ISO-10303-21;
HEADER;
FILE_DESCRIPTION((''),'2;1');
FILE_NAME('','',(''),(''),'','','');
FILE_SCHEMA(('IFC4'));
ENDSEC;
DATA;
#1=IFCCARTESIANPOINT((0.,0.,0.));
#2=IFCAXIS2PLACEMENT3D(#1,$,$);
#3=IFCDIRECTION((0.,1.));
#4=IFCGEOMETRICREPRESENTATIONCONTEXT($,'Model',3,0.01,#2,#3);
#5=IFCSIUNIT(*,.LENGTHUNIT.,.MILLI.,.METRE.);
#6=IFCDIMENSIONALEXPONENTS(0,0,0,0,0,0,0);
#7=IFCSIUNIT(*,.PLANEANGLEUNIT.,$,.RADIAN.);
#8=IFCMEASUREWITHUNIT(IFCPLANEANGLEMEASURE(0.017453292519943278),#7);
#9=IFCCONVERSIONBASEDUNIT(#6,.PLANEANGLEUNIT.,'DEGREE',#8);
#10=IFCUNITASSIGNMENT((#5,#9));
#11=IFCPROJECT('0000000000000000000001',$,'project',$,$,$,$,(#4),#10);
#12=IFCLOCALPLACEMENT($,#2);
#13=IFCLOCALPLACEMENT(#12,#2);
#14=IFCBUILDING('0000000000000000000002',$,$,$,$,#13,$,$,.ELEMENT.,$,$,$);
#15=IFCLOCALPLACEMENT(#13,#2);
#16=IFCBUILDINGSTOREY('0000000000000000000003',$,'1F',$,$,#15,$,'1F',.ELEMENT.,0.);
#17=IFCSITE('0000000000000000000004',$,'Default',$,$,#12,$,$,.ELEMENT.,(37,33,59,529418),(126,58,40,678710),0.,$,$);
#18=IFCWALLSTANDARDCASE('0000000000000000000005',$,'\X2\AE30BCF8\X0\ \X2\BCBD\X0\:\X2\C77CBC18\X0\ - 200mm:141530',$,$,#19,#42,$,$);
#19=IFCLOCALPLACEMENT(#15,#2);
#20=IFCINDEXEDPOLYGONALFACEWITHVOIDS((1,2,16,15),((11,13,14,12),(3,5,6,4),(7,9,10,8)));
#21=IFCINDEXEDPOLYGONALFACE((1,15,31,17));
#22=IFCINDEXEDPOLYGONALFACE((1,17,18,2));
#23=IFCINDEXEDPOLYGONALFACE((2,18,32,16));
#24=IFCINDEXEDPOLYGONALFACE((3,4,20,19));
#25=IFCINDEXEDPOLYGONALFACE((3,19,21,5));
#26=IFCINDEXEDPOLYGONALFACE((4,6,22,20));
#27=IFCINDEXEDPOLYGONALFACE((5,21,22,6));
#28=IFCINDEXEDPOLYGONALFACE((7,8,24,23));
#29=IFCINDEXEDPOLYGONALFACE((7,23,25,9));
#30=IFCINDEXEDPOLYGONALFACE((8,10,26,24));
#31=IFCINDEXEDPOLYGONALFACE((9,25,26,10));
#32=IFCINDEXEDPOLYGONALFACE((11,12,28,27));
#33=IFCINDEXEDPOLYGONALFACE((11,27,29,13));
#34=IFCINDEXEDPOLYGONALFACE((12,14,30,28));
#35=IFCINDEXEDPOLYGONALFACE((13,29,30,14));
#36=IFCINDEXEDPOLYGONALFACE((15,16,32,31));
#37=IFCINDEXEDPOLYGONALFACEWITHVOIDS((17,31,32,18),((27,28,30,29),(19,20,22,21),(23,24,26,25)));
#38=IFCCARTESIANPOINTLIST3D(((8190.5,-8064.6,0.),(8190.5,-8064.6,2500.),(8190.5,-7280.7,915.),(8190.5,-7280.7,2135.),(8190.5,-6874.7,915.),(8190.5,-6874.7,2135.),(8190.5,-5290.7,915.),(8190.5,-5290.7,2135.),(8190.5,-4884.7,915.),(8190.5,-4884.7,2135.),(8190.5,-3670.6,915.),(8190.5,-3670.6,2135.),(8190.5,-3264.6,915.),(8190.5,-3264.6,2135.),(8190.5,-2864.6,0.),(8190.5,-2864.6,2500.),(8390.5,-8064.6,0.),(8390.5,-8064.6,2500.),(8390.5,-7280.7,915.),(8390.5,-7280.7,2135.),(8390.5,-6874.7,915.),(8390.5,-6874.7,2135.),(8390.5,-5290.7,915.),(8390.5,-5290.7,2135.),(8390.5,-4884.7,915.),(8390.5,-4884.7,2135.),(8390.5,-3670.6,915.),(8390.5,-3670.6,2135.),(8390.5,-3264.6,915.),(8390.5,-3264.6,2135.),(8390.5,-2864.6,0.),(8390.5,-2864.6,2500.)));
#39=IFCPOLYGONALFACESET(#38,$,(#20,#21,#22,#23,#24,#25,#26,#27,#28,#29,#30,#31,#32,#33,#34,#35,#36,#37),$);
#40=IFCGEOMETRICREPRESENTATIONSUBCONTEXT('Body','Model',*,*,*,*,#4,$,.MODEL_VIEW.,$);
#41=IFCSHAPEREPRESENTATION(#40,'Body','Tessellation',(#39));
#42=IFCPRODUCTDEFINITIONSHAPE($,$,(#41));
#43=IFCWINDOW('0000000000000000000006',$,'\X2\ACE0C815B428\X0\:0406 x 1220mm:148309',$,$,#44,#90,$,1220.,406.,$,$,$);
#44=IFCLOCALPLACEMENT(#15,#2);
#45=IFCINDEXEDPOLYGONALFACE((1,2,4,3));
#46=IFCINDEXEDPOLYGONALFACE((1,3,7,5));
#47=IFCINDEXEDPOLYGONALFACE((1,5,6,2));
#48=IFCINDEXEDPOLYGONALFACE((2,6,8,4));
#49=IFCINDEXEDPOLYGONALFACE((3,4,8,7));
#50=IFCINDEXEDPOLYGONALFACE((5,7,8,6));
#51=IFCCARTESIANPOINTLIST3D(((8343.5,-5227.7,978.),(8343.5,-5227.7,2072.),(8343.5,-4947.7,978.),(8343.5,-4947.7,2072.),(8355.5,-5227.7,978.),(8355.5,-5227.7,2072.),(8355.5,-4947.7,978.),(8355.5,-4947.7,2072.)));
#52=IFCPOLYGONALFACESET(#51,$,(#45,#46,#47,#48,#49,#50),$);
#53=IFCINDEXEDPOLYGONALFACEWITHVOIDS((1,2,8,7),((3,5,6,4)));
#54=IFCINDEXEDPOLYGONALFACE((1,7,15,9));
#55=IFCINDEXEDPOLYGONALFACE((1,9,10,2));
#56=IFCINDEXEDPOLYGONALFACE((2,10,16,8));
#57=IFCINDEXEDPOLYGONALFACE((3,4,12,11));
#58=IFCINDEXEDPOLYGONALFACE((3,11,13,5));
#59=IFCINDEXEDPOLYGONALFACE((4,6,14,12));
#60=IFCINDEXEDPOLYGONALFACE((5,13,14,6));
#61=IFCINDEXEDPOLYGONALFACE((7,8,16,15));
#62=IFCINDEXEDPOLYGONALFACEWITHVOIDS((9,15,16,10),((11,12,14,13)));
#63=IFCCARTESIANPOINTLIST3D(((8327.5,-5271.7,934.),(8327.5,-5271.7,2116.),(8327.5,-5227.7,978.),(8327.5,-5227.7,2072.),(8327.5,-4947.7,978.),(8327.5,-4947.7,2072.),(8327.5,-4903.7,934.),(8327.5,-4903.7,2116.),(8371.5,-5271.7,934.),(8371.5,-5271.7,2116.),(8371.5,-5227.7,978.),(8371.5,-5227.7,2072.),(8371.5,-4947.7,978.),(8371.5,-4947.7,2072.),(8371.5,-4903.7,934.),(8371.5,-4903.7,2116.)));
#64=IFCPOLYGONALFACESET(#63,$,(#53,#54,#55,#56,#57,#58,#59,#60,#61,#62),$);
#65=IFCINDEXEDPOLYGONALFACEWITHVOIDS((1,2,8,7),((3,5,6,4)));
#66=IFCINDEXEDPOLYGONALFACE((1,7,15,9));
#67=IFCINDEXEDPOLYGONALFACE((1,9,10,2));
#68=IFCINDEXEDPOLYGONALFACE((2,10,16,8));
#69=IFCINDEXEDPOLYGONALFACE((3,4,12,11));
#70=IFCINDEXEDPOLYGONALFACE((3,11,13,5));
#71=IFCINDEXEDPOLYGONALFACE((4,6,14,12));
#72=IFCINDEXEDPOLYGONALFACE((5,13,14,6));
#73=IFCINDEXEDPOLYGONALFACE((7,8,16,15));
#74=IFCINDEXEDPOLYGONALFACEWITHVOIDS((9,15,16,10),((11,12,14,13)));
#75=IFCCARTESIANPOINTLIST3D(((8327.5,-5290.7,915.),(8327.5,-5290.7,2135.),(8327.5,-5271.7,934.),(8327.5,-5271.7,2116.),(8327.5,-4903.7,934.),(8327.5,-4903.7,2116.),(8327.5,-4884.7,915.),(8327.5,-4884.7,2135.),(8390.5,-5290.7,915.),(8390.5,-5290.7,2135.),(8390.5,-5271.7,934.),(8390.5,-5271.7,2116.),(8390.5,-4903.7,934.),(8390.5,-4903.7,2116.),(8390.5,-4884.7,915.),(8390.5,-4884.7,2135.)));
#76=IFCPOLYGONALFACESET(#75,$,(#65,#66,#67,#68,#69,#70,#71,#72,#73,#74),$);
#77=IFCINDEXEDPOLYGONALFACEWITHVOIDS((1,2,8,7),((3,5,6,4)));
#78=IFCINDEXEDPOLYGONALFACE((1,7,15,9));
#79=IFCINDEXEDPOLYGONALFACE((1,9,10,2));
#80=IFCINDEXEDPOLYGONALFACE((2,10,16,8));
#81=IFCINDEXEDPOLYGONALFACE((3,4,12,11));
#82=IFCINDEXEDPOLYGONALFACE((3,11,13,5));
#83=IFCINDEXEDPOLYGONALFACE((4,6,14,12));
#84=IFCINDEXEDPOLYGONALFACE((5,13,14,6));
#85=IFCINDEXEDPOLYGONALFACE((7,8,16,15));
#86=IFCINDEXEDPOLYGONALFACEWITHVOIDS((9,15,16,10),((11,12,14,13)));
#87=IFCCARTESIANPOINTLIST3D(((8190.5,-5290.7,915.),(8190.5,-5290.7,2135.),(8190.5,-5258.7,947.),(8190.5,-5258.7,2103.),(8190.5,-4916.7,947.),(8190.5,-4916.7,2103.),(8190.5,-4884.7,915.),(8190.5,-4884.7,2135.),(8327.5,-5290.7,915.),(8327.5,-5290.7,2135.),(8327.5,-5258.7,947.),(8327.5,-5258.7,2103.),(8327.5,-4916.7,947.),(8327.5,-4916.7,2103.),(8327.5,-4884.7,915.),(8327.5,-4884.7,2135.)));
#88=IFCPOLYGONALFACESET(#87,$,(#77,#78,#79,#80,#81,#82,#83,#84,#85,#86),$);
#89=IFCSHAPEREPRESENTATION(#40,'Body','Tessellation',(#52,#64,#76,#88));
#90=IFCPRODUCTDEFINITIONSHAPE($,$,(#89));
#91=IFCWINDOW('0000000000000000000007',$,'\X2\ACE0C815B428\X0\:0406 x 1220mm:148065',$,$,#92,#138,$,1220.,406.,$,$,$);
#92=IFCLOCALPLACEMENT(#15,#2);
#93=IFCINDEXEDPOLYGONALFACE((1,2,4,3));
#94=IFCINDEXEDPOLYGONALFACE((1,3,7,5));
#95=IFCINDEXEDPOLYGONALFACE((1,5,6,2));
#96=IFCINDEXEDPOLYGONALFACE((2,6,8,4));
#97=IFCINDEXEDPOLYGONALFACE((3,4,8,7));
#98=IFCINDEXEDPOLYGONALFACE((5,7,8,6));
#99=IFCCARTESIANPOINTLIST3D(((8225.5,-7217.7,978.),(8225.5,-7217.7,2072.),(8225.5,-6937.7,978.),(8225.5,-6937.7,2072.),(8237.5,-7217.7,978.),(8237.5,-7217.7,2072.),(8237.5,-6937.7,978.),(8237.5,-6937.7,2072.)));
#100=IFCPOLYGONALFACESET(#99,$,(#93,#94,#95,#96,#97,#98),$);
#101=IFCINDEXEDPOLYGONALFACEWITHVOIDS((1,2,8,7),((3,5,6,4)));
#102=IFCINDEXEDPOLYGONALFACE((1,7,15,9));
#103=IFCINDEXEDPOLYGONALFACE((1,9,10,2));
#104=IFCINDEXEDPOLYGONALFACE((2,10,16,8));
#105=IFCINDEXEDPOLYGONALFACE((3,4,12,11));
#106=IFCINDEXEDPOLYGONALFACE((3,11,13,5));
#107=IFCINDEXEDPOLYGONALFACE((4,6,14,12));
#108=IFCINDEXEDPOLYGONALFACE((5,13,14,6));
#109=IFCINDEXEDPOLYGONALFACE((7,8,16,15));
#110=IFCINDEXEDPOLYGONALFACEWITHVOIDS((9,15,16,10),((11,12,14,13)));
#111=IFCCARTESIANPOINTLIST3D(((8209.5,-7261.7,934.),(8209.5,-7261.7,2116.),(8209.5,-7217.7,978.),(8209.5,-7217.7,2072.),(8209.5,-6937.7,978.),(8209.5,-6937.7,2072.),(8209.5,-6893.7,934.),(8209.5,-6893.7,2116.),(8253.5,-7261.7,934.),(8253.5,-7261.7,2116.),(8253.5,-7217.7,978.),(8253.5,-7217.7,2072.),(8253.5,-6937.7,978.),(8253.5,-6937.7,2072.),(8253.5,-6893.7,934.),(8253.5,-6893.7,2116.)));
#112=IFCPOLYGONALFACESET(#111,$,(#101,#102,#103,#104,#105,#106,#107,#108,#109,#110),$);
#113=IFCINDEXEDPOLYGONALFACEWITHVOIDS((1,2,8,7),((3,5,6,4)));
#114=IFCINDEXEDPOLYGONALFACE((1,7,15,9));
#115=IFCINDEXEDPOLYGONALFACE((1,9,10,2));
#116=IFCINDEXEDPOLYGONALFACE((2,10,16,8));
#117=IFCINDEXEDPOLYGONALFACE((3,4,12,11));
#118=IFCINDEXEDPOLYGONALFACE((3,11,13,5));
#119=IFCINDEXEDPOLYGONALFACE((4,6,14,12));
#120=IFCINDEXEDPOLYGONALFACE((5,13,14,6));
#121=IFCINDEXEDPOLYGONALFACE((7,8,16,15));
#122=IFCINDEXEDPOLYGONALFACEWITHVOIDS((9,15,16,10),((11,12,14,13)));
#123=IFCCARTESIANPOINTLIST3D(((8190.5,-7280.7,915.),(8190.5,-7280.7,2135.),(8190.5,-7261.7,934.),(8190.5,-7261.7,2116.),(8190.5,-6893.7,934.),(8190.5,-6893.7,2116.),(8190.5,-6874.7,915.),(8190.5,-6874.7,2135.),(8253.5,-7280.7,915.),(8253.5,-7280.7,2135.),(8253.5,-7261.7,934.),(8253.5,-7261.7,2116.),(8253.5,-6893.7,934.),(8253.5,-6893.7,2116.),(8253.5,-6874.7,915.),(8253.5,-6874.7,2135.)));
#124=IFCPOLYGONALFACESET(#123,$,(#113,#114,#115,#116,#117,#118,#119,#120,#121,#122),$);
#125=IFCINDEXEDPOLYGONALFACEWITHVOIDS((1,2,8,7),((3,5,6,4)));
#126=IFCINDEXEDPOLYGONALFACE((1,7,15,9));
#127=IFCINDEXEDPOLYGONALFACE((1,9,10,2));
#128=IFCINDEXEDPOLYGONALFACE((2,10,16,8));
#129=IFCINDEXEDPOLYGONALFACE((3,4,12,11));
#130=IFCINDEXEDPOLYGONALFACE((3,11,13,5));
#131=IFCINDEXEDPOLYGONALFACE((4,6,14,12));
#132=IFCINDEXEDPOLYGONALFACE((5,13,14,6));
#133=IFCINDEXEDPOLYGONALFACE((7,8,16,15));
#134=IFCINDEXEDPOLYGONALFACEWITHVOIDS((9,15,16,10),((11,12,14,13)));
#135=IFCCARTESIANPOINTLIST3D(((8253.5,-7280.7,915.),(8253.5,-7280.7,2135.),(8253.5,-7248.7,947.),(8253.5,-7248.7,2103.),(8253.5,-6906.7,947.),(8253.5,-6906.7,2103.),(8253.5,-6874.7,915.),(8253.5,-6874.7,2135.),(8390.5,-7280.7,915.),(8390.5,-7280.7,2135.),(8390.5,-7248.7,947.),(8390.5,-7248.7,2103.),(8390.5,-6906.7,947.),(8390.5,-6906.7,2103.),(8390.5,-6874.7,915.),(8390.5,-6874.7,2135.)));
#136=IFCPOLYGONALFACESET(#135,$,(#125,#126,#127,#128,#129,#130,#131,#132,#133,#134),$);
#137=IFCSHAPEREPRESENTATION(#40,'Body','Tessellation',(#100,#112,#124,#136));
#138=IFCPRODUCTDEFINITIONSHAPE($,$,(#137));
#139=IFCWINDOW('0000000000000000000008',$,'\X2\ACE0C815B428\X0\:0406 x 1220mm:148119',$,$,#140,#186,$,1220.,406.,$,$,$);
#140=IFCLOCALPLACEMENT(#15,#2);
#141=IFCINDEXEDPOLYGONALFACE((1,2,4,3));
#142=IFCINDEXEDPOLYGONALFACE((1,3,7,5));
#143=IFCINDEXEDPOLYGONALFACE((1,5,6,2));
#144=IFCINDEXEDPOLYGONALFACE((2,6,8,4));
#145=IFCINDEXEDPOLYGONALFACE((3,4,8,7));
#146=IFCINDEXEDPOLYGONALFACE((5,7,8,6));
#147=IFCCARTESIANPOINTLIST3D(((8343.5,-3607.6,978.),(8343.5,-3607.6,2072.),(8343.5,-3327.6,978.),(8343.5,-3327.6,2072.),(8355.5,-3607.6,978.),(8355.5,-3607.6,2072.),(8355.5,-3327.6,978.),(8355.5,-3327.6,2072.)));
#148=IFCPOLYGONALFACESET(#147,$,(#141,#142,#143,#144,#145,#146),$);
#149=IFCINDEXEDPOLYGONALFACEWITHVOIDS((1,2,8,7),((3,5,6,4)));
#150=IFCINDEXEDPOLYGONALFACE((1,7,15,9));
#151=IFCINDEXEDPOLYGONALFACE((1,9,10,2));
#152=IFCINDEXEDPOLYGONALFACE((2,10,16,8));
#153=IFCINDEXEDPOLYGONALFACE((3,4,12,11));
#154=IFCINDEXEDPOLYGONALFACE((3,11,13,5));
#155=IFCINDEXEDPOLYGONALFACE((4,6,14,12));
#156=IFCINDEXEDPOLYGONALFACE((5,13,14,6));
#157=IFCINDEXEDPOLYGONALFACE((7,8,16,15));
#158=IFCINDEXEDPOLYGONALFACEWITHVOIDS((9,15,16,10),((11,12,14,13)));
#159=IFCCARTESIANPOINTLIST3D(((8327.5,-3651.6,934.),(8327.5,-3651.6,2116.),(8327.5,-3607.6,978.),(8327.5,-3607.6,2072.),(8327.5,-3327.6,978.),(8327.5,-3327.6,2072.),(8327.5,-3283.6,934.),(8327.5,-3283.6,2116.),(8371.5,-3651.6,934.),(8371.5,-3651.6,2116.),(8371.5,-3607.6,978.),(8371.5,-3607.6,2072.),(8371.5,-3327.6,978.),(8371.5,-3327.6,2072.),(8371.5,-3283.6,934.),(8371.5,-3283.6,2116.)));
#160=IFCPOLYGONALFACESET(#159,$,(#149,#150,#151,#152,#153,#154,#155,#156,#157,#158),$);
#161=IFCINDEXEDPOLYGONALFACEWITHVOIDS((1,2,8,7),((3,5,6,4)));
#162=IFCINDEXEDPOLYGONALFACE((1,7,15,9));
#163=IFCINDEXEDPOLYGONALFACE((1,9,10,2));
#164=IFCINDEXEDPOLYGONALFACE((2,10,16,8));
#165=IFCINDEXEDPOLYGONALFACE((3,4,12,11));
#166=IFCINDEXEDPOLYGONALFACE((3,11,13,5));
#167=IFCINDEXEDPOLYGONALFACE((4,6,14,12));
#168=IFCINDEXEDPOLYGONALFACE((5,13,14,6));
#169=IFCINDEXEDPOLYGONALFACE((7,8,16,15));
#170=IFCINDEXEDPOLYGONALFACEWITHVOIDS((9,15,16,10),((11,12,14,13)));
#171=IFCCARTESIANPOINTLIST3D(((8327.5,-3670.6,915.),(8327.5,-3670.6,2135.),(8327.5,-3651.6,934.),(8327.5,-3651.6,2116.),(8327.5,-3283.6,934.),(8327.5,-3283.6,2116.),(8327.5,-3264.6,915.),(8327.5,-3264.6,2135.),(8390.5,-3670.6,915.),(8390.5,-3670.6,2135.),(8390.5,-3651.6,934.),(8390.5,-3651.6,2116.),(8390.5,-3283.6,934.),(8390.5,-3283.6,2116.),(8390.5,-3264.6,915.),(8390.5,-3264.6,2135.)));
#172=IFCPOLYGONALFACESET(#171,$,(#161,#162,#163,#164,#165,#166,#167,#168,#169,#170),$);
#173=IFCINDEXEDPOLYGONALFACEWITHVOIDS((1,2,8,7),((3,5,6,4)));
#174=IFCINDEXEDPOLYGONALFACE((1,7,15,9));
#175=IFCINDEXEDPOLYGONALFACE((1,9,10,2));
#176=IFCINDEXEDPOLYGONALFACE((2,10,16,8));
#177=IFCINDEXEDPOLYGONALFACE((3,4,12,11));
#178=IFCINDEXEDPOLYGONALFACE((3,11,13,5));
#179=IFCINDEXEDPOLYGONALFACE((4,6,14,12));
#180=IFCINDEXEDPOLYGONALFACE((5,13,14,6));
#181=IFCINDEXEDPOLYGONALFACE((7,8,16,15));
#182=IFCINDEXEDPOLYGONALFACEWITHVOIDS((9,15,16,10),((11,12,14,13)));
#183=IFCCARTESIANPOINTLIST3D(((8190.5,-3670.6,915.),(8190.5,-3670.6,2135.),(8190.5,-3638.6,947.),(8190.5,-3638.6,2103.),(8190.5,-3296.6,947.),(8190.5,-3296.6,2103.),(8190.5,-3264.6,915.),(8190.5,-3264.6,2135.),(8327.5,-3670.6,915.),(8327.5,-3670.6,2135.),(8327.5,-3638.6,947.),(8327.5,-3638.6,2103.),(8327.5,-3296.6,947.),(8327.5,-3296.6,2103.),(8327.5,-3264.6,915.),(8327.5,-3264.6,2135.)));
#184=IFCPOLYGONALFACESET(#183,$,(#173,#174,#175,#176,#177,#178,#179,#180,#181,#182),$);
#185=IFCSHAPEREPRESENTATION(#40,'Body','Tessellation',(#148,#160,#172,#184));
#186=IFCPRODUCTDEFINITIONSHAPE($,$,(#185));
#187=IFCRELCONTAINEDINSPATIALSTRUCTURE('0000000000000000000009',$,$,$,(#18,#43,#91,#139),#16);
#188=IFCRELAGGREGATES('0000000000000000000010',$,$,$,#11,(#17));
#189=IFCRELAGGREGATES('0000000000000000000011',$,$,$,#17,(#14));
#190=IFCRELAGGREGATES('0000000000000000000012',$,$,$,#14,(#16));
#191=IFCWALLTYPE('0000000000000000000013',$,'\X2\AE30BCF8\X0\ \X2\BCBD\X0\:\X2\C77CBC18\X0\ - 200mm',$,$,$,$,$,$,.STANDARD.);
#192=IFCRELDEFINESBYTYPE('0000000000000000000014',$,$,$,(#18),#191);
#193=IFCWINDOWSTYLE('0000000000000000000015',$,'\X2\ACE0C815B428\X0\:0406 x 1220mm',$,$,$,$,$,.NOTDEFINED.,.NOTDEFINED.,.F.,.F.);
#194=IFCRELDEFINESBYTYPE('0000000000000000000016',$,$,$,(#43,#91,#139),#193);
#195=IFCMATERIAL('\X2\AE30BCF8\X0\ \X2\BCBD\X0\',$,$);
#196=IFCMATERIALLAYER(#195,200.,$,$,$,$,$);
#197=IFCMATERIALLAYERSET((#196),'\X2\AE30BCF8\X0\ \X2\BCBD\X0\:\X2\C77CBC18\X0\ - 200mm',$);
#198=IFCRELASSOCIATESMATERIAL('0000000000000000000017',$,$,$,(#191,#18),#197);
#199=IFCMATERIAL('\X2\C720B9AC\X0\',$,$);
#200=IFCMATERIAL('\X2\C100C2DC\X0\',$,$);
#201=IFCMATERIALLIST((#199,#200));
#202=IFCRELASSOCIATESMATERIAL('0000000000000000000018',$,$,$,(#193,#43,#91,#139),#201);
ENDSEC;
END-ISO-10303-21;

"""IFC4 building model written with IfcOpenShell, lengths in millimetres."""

from ifc_helpers import new_model, entity, si_unit, converted_unit, direction, frame, frame_2d, origin, place, context, subcontext, project, spatial, polyline, rectangle, outline, extrude, source, transform, mapped, material, material_list, layer, layer_set, layer_usage, type_object, type_shapes, element, fill, save


model = new_model("IFC4")

# Units and contexts
model_context = context("Model", 3, precision=0.01, world=origin(), true_north=direction((0.0, 1.0)))
body_context = subcontext(model_context, "Body", "Model", "MODEL_VIEW")
ifc_project = project(units=[si_unit("LENGTHUNIT", "METRE", prefix="MILLI"), converted_unit("PLANEANGLEUNIT", "DEGREE", entity("IfcPlaneAngleMeasure", 0.017453292519943278), si_unit("PLANEANGLEUNIT", "RADIAN"), dimensions=[0, 0, 0, 0, 0, 0, 0])], contexts=[model_context])

# Site, building, storey
site_placement = place(None, origin())
site = spatial("IfcSite", under=ifc_project, at=site_placement, Name="Default", CompositionType="ELEMENT", RefLatitude=(37, 33, 59, 529418), RefLongitude=(126, 58, 40, 678710), RefElevation=0.0)
building_placement = place(site_placement, origin())
building = spatial("IfcBuilding", under=site, at=building_placement, CompositionType="ELEMENT")
storey_placement = place(building_placement, origin())
storey = spatial("IfcBuildingStorey", under=building, at=storey_placement, Name="1F", LongName="1F", CompositionType="ELEMENT", Elevation=0.0)

# Wall, openings, windows
ifc_material_1 = material(Name="기본 벽")
ifc_layer = layer(ifc_material_1, 200.0)
ifc_layer_set = layer_set([ifc_layer], Name="기본 벽:일반 - 200mm")
ifc_layer_usage_1 = layer_usage(ifc_layer_set, "AXIS2", "NEGATIVE", 100.0)
wall_type = type_object("IfcWallType", Name="기본 벽:일반 - 200mm", PredefinedType="STANDARD", material=ifc_layer_set)
wall_1_placement = place(storey_placement, frame((8290.5, -2864.6, 0.0), z_axis=(0.0, 0.0, 1.0), x_axis=(0.0, -1.0, 0.0)))
wall_1 = element("IfcWallStandardCase", 1, at=wall_1_placement, inside=storey, type_object=wall_type, material=ifc_layer_usage_1, Name="기본 벽:일반 - 200mm:141530", context=body_context, shape_type="SweptSolid", body=[
    extrude(rectangle(XDim=5200.0, YDim=200.0, at=frame_2d((2600.0, 0.0), x_axis=(-1.0, 0.0))), origin(), (0.0, 0.0, 1.0), 2500.0),
])
opening_1_placement = place(wall_1_placement, frame((2020.1, -100.0, 915.0)))
opening_1 = element("IfcOpeningElement", 2, at=opening_1_placement, cuts=wall_1, ObjectType="Opening", context=body_context, shape_type="SweptSolid", body=[
    extrude(rectangle(XDim=1220.0, YDim=406.0, at=frame_2d((610.0, 203.0), x_axis=(1.0, 0.0))), frame((0.0, 0.0, 0.0), z_axis=(0.0, 1.0, 0.0), x_axis=(0.0, 0.0, 1.0)), (0.0, 0.0, 1.0), 200.0),
])
opening_2_placement = place(wall_1_placement, frame((4416.1, 100.0, 915.0)))
opening_2 = element("IfcOpeningElement", 3, at=opening_2_placement, cuts=wall_1, ObjectType="Opening", context=body_context, shape_type="SweptSolid", body=[
    extrude(rectangle(XDim=1220.0, YDim=406.0, at=frame_2d((610.0, 203.0), x_axis=(1.0, 0.0))), frame((0.0, 0.0, 0.0), z_axis=(0.0, -1.0, 0.0), x_axis=(0.0, 0.0, 1.0)), (0.0, 0.0, 1.0), 200.0),
])
opening_3_placement = place(wall_1_placement, frame((400.0, -100.0, 915.0)))
opening_3 = element("IfcOpeningElement", 4, at=opening_3_placement, cuts=wall_1, ObjectType="Opening", context=body_context, shape_type="SweptSolid", body=[
    extrude(rectangle(XDim=1220.0, YDim=406.0, at=frame_2d((610.0, 203.0), x_axis=(1.0, 0.0))), frame((0.0, 0.0, 0.0), z_axis=(0.0, 1.0, 0.0), x_axis=(0.0, 0.0, 1.0)), (0.0, 0.0, 1.0), 200.0),
])
ifc_material_2 = material(Name="유리")
ifc_material_3 = material(Name="섀시")
ifc_material_list_1 = material_list([ifc_material_2, ifc_material_3])
window_style_1 = type_object("IfcWindowStyle", Name="고정됨:0406 x 1220mm", ConstructionType="NOTDEFINED", OperationType="NOTDEFINED", ParameterTakesPrecedence=False, Sizeable=False, material=ifc_material_list_1)
shared_shape_1 = source(origin(), body_context, "Body", "SweptSolid", [
    extrude(rectangle(XDim=12.0, YDim=280.0, at=frame_2d((0.0, 0.0), x_axis=(1.0, 0.0))), frame((203.0, 159.0, 63.0), z_axis=(0.0, 0.0, 1.0), x_axis=(0.0, -1.0, 0.0)), (0.0, 0.0, 1.0), 1094.0),
    extrude(outline(polyline([(-184.0, -591.0), (184.0, -591.0), (184.0, 591.0), (-184.0, 591.0), (-184.0, -591.0)]), holes=[polyline([(-140.0, -547.0), (-140.0, 547.0), (140.0, 547.0), (140.0, -547.0), (-140.0, -547.0)])]), frame((203.0, 137.0, 610.0), z_axis=(0.0, 1.0, 0.0), x_axis=(1.0, 0.0, 0.0)), (0.0, 0.0, 1.0), 44.0),
    extrude(outline(polyline([(-203.0, -610.0), (203.0, -610.0), (203.0, 610.0), (-203.0, 610.0), (-203.0, -610.0)]), holes=[polyline([(-184.0, -591.0), (-184.0, 591.0), (184.0, 591.0), (184.0, -591.0), (-184.0, -591.0)])]), frame((203.0, 137.0, 610.0), z_axis=(0.0, 1.0, 0.0), x_axis=(1.0, 0.0, 0.0)), (0.0, 0.0, 1.0), 63.0),
    extrude(outline(polyline([(-203.0, -610.0), (203.0, -610.0), (203.0, 610.0), (-203.0, 610.0), (-203.0, -610.0)]), holes=[polyline([(-171.0, -578.0), (-171.0, 578.0), (171.0, 578.0), (171.0, -578.0), (-171.0, -578.0)])]), frame((203.0, 0.0, 610.0), z_axis=(0.0, 1.0, 0.0), x_axis=(1.0, 0.0, 0.0)), (0.0, 0.0, 1.0), 137.0),
])
type_shapes(window_style_1, [shared_shape_1])
window_1_placement = place(opening_1_placement, origin())
window_1 = element("IfcWindow", 5, at=window_1_placement, inside=storey, type_object=window_style_1, material=ifc_material_list_1, Name="고정됨:0406 x 1220mm:148309", OverallHeight=1220.0, OverallWidth=406.0, context=body_context, shape_type="MappedRepresentation", body=[
    mapped(shared_shape_1, transform((0.0, 0.0, 0.0), scale=1.0)),
])
fill(opening_1, window_1)
window_2_placement = place(opening_2_placement, frame((0.0, 0.0, 0.0), z_axis=(0.0, 0.0, 1.0), x_axis=(-1.0, 0.0, 0.0)))
window_2 = element("IfcWindow", 6, at=window_2_placement, inside=storey, type_object=window_style_1, material=ifc_material_list_1, Name="고정됨:0406 x 1220mm:148065", OverallHeight=1220.0, OverallWidth=406.0, context=body_context, shape_type="MappedRepresentation", body=[
    mapped(shared_shape_1, transform((0.0, 0.0, 0.0), scale=1.0)),
])
fill(opening_2, window_2)
window_3_placement = place(opening_3_placement, origin())
window_3 = element("IfcWindow", 7, at=window_3_placement, inside=storey, type_object=window_style_1, material=ifc_material_list_1, Name="고정됨:0406 x 1220mm:148119", OverallHeight=1220.0, OverallWidth=406.0, context=body_context, shape_type="MappedRepresentation", body=[
    mapped(shared_shape_1, transform((0.0, 0.0, 0.0), scale=1.0)),
])
fill(opening_3, window_3)

save(model, "model.ifc")
